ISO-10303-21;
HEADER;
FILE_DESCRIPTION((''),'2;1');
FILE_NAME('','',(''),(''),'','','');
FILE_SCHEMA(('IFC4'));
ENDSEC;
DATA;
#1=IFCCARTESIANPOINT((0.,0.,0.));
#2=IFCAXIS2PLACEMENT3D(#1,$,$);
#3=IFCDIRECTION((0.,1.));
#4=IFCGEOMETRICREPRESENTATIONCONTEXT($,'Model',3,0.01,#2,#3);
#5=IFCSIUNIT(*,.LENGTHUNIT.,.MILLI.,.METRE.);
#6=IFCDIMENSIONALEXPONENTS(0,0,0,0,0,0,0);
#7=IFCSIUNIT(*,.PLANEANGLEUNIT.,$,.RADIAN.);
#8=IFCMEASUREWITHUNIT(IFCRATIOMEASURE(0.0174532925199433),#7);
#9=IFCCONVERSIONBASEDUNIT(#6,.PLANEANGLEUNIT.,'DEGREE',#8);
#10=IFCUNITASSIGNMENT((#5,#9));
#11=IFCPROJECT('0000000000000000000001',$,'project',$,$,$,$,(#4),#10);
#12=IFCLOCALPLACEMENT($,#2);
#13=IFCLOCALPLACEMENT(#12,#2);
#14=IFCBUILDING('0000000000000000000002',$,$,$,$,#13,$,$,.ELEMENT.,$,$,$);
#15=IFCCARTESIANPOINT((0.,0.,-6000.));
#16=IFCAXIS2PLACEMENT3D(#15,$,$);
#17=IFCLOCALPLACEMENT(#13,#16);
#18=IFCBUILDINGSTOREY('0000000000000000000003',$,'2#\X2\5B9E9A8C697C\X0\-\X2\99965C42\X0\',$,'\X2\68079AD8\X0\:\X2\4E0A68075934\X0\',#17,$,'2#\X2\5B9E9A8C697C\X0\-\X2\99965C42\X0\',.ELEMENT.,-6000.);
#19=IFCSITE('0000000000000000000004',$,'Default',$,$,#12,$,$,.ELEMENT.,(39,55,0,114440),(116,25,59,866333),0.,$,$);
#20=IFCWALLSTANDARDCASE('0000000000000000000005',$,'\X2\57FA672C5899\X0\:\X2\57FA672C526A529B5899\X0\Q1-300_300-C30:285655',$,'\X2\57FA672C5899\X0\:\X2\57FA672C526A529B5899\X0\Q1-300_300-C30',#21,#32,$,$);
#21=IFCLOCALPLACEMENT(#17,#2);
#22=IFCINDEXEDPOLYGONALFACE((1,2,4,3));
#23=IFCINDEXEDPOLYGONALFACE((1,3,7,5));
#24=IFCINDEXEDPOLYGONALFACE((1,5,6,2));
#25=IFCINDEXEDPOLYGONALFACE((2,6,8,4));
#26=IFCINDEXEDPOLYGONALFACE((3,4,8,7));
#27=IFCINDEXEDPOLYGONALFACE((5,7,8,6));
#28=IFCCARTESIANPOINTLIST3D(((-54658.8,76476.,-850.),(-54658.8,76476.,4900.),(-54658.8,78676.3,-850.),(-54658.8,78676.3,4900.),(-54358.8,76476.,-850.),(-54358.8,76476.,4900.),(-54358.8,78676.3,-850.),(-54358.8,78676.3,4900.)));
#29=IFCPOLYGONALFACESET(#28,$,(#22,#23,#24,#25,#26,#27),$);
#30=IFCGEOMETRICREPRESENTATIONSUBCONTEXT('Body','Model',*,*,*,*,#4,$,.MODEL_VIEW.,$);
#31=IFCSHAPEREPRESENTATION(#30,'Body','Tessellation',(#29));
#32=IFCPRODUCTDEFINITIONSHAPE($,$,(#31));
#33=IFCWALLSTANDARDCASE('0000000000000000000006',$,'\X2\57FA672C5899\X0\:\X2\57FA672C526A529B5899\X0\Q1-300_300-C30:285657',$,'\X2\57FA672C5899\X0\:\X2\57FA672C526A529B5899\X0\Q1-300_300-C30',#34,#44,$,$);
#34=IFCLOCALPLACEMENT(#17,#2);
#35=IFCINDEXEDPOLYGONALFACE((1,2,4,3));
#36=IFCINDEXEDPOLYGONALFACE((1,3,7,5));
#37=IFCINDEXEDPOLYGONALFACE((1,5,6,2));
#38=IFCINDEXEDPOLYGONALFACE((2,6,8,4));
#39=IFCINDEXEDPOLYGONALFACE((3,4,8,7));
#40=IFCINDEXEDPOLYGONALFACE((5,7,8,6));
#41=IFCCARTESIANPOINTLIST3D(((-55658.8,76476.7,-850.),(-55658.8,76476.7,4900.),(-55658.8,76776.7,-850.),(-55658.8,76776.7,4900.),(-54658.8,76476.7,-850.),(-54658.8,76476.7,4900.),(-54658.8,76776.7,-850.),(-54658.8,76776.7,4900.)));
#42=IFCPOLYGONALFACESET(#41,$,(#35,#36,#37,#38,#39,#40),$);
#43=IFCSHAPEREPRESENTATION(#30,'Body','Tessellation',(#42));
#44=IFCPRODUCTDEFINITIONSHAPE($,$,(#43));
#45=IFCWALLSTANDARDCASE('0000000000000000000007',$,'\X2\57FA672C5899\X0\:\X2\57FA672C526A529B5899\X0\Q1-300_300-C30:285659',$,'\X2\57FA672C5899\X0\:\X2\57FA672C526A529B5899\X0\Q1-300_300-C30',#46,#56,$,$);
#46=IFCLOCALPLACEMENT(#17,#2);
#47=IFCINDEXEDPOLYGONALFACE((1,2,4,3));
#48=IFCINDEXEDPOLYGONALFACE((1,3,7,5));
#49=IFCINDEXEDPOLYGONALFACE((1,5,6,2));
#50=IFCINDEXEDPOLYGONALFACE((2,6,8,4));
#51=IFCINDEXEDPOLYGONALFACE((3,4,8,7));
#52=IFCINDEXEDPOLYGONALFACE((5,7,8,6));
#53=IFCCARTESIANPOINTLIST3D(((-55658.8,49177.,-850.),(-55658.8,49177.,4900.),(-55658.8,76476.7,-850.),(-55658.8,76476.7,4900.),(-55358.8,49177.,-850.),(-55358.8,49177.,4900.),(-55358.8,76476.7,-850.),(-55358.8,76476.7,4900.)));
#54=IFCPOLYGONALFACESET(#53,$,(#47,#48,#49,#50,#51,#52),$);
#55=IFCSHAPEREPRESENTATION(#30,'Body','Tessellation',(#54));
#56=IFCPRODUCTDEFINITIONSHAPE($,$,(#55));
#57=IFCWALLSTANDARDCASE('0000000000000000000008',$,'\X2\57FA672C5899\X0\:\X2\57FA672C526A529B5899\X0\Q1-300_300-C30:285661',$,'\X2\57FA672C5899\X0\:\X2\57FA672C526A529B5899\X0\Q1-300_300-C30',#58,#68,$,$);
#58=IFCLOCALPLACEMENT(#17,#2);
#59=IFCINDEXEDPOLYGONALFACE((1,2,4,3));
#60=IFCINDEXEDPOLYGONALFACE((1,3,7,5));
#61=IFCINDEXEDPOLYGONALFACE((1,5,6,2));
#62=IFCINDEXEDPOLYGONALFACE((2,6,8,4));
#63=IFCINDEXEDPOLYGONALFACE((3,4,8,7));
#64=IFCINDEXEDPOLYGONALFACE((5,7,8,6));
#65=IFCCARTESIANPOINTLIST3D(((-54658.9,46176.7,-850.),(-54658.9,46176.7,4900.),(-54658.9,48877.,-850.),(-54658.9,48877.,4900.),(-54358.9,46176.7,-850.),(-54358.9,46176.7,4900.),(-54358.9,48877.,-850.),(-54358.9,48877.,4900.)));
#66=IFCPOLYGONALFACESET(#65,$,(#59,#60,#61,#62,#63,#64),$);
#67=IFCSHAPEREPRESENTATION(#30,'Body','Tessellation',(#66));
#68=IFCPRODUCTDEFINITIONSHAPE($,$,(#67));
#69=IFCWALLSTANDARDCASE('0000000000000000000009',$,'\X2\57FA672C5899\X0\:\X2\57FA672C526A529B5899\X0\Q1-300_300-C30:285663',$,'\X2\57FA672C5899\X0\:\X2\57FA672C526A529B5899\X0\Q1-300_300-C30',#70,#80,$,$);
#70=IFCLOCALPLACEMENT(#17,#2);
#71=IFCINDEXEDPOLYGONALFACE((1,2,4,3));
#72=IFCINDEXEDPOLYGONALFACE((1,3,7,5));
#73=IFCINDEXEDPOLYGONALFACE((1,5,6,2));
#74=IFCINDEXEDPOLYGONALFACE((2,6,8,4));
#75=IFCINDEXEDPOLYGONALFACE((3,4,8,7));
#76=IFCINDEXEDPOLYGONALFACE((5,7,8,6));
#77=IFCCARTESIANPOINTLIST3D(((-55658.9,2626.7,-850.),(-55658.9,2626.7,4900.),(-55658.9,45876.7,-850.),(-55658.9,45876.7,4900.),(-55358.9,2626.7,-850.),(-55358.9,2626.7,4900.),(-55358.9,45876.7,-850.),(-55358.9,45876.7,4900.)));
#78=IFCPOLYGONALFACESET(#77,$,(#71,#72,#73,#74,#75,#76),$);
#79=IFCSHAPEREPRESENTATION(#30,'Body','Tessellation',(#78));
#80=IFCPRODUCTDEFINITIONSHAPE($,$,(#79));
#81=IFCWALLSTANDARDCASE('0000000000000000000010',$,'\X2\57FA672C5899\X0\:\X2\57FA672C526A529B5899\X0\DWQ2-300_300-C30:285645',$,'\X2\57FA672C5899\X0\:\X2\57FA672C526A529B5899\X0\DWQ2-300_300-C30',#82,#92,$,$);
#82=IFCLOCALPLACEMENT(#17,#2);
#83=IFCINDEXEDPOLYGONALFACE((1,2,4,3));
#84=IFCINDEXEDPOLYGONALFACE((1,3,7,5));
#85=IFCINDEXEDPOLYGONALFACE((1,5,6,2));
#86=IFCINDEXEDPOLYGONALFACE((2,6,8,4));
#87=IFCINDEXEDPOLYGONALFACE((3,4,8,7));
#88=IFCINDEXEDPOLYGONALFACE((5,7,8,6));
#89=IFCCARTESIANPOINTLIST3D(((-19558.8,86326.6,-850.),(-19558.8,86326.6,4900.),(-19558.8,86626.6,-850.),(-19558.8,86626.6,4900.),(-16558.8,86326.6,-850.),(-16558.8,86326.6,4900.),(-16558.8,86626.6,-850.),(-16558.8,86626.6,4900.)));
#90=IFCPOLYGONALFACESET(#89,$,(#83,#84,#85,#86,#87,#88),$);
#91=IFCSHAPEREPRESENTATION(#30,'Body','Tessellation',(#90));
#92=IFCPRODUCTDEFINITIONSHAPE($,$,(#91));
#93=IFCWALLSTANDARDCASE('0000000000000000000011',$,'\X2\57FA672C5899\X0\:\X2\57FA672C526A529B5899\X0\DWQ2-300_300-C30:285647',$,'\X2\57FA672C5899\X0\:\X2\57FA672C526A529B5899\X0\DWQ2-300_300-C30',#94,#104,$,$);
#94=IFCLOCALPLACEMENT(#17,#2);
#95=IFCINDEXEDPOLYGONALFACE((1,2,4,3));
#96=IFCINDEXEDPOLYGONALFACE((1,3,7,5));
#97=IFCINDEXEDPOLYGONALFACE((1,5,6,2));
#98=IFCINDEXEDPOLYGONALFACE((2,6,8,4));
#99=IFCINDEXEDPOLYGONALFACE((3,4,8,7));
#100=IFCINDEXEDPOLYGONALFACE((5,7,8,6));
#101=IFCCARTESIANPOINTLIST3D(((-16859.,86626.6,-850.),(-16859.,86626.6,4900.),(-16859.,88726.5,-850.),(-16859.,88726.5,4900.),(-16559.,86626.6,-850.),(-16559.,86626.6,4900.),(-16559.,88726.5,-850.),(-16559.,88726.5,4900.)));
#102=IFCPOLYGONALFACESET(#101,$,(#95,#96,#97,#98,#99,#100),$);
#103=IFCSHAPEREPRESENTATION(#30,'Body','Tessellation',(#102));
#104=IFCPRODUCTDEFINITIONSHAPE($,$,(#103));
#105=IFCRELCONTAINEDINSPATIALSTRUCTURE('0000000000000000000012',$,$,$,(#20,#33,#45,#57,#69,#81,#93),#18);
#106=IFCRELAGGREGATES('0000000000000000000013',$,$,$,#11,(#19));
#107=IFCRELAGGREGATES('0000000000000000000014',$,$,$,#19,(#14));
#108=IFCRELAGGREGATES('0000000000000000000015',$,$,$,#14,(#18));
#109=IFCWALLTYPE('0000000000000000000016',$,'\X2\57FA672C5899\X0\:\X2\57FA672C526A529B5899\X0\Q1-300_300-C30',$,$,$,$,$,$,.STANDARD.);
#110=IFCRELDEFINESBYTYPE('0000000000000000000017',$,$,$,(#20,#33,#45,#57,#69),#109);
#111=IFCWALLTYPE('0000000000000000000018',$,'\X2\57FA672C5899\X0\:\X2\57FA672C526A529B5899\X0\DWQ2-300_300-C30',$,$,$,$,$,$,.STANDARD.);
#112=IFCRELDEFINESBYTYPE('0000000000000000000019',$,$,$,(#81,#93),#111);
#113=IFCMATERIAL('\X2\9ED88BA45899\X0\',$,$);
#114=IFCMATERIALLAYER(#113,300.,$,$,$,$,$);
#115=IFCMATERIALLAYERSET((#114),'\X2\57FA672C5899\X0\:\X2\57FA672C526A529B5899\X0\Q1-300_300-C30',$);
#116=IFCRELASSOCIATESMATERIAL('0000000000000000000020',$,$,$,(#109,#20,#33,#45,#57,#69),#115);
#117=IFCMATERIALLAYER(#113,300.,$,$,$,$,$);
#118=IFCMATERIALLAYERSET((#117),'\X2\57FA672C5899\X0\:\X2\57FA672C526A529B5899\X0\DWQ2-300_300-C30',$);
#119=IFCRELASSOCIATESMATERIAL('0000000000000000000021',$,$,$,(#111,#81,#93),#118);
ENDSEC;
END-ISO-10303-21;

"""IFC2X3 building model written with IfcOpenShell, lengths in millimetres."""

from ifc_helpers import new_model, entity, si_unit, converted_unit, direction, frame, frame_2d, origin, place, context, subcontext, project, spatial, rectangle, extrude, material, layer, layer_set, layer_usage, type_object, element, save


model = new_model("IFC2X3")

# Units and contexts
model_context = context("Model", 3, precision=0.01, world=origin(), true_north=direction((0.0, 1.0)))
body_context = subcontext(model_context, "Body", "Model", "MODEL_VIEW")
ifc_project = project(units=[si_unit("LENGTHUNIT", "METRE", prefix="MILLI"), converted_unit("PLANEANGLEUNIT", "DEGREE", entity("IfcRatioMeasure", 0.0174532925199433), si_unit("PLANEANGLEUNIT", "RADIAN"), dimensions=[0, 0, 0, 0, 0, 0, 0])], contexts=[model_context])

# Site, building, storey
site_placement = place(None, origin())
site = spatial("IfcSite", under=ifc_project, at=site_placement, Name="Default", CompositionType="ELEMENT", RefLatitude=(39, 55, 0, 114440), RefLongitude=(116, 25, 59, 866333), RefElevation=0.0)
building_placement = place(site_placement, origin())
building = spatial("IfcBuilding", under=site, at=building_placement, CompositionType="ELEMENT")
storey_placement = place(building_placement, frame((0.0, 0.0, -6000.0)))
storey = spatial("IfcBuildingStorey", under=building, at=storey_placement, Name="2#实验楼-首层", ObjectType="标高:上标头", LongName="2#实验楼-首层", CompositionType="ELEMENT", Elevation=-6000.0)

# Walls
ifc_material_1 = material(Name="默认墙")
ifc_layer_1 = layer(ifc_material_1, 300.0)
ifc_layer_set_1 = layer_set([ifc_layer_1], Name="基本墙:基本剪力墙Q1-300_300-C30")
wall_type_1 = type_object("IfcWallType", Name="基本墙:基本剪力墙Q1-300_300-C30", PredefinedType="STANDARD", material=ifc_layer_set_1)
ifc_layer_usage_1 = layer_usage(ifc_layer_set_1, "AXIS2", "NEGATIVE", 150.0)
wall_1_placement = place(storey_placement, frame((-54508.8, 76476.0, -850.0), z_axis=(0.0, 0.0, 1.0), x_axis=(0.0, 1.0, 0.0)))
element("IfcWallStandardCase", 1, at=wall_1_placement, inside=storey, type_object=wall_type_1, material=ifc_layer_usage_1, Name="基本墙:基本剪力墙Q1-300_300-C30:285655", ObjectType="基本墙:基本剪力墙Q1-300_300-C30", context=body_context, shape_type="SweptSolid", body=[
    extrude(rectangle(XDim=2200.3, YDim=300.0, at=frame_2d((1100.2, 0.0), x_axis=(-1.0, 0.0))), origin(), (0.0, 0.0, 1.0), 5750.0),
])
ifc_layer_usage_2 = layer_usage(ifc_layer_set_1, "AXIS2", "NEGATIVE", 150.0)
wall_2_placement = place(storey_placement, frame((-55658.8, 76626.7, -850.0)))
element("IfcWallStandardCase", 2, at=wall_2_placement, inside=storey, type_object=wall_type_1, material=ifc_layer_usage_2, Name="基本墙:基本剪力墙Q1-300_300-C30:285657", ObjectType="基本墙:基本剪力墙Q1-300_300-C30", context=body_context, shape_type="SweptSolid", body=[
    extrude(rectangle(XDim=1000.0, YDim=300.0, at=frame_2d((500.0, 0.0), x_axis=(-1.0, 0.0))), origin(), (0.0, 0.0, 1.0), 5750.0),
])
ifc_layer_usage_3 = layer_usage(ifc_layer_set_1, "AXIS2", "NEGATIVE", 150.0)
wall_3_placement = place(storey_placement, frame((-55508.8, 49177.0, -850.0), z_axis=(0.0, 0.0, 1.0), x_axis=(0.0, 1.0, 0.0)))
element("IfcWallStandardCase", 3, at=wall_3_placement, inside=storey, type_object=wall_type_1, material=ifc_layer_usage_3, Name="基本墙:基本剪力墙Q1-300_300-C30:285659", ObjectType="基本墙:基本剪力墙Q1-300_300-C30", context=body_context, shape_type="SweptSolid", body=[
    extrude(rectangle(XDim=27299.7, YDim=300.0, at=frame_2d((13649.8, 0.0), x_axis=(-1.0, 0.0))), origin(), (0.0, 0.0, 1.0), 5750.0),
])
ifc_layer_usage_4 = layer_usage(ifc_layer_set_1, "AXIS2", "NEGATIVE", 150.0)
wall_4_placement = place(storey_placement, frame((-54508.9, 46176.7, -850.0), z_axis=(0.0, 0.0, 1.0), x_axis=(0.0, 1.0, 0.0)))
element("IfcWallStandardCase", 4, at=wall_4_placement, inside=storey, type_object=wall_type_1, material=ifc_layer_usage_4, Name="基本墙:基本剪力墙Q1-300_300-C30:285661", ObjectType="基本墙:基本剪力墙Q1-300_300-C30", context=body_context, shape_type="SweptSolid", body=[
    extrude(rectangle(XDim=2700.3, YDim=300.0, at=frame_2d((1350.2, 0.0), x_axis=(-1.0, 0.0))), origin(), (0.0, 0.0, 1.0), 5750.0),
])
ifc_layer_usage_5 = layer_usage(ifc_layer_set_1, "AXIS2", "NEGATIVE", 150.0)
wall_5_placement = place(storey_placement, frame((-55508.9, 2626.7, -850.0), z_axis=(0.0, 0.0, 1.0), x_axis=(0.000002, 1.0, 0.0)))
element("IfcWallStandardCase", 5, at=wall_5_placement, inside=storey, type_object=wall_type_1, material=ifc_layer_usage_5, Name="基本墙:基本剪力墙Q1-300_300-C30:285663", ObjectType="基本墙:基本剪力墙Q1-300_300-C30", context=body_context, shape_type="SweptSolid", body=[
    extrude(rectangle(XDim=43250.0, YDim=300.0, at=frame_2d((21625.0, 0.0), x_axis=(-1.0, 0.0))), origin(), (0.0, 0.0, 1.0), 5750.0),
])
ifc_layer_2 = layer(ifc_material_1, 300.0)
ifc_layer_set_2 = layer_set([ifc_layer_2], Name="基本墙:基本剪力墙DWQ2-300_300-C30")
ifc_layer_usage_6 = layer_usage(ifc_layer_set_2, "AXIS2", "NEGATIVE", 150.0)
wall_type_2 = type_object("IfcWallType", Name="基本墙:基本剪力墙DWQ2-300_300-C30", PredefinedType="STANDARD", material=ifc_layer_set_2)
wall_6_placement = place(storey_placement, frame((-19558.8, 86476.6, -850.0)))
element("IfcWallStandardCase", 6, at=wall_6_placement, inside=storey, type_object=wall_type_2, material=ifc_layer_usage_6, Name="基本墙:基本剪力墙DWQ2-300_300-C30:285645", ObjectType="基本墙:基本剪力墙DWQ2-300_300-C30", context=body_context, shape_type="SweptSolid", body=[
    extrude(rectangle(XDim=3000.0, YDim=300.0, at=frame_2d((1500.0, 0.0), x_axis=(-1.0, 0.0))), origin(), (0.0, 0.0, 1.0), 5750.0),
])
ifc_layer_usage_7 = layer_usage(ifc_layer_set_2, "AXIS2", "NEGATIVE", 150.0)
wall_7_placement = place(storey_placement, frame((-16709.0, 86626.6, -850.0), z_axis=(0.0, 0.0, 1.0), x_axis=(0.0, 1.0, 0.0)))
element("IfcWallStandardCase", 7, at=wall_7_placement, inside=storey, type_object=wall_type_2, material=ifc_layer_usage_7, Name="基本墙:基本剪力墙DWQ2-300_300-C30:285647", ObjectType="基本墙:基本剪力墙DWQ2-300_300-C30", context=body_context, shape_type="SweptSolid", body=[
    extrude(rectangle(XDim=2099.9, YDim=300.0, at=frame_2d((1050.0, 0.0), x_axis=(-1.0, 0.0))), origin(), (0.0, 0.0, 1.0), 5750.0),
])

save(model, "model.ifc")
